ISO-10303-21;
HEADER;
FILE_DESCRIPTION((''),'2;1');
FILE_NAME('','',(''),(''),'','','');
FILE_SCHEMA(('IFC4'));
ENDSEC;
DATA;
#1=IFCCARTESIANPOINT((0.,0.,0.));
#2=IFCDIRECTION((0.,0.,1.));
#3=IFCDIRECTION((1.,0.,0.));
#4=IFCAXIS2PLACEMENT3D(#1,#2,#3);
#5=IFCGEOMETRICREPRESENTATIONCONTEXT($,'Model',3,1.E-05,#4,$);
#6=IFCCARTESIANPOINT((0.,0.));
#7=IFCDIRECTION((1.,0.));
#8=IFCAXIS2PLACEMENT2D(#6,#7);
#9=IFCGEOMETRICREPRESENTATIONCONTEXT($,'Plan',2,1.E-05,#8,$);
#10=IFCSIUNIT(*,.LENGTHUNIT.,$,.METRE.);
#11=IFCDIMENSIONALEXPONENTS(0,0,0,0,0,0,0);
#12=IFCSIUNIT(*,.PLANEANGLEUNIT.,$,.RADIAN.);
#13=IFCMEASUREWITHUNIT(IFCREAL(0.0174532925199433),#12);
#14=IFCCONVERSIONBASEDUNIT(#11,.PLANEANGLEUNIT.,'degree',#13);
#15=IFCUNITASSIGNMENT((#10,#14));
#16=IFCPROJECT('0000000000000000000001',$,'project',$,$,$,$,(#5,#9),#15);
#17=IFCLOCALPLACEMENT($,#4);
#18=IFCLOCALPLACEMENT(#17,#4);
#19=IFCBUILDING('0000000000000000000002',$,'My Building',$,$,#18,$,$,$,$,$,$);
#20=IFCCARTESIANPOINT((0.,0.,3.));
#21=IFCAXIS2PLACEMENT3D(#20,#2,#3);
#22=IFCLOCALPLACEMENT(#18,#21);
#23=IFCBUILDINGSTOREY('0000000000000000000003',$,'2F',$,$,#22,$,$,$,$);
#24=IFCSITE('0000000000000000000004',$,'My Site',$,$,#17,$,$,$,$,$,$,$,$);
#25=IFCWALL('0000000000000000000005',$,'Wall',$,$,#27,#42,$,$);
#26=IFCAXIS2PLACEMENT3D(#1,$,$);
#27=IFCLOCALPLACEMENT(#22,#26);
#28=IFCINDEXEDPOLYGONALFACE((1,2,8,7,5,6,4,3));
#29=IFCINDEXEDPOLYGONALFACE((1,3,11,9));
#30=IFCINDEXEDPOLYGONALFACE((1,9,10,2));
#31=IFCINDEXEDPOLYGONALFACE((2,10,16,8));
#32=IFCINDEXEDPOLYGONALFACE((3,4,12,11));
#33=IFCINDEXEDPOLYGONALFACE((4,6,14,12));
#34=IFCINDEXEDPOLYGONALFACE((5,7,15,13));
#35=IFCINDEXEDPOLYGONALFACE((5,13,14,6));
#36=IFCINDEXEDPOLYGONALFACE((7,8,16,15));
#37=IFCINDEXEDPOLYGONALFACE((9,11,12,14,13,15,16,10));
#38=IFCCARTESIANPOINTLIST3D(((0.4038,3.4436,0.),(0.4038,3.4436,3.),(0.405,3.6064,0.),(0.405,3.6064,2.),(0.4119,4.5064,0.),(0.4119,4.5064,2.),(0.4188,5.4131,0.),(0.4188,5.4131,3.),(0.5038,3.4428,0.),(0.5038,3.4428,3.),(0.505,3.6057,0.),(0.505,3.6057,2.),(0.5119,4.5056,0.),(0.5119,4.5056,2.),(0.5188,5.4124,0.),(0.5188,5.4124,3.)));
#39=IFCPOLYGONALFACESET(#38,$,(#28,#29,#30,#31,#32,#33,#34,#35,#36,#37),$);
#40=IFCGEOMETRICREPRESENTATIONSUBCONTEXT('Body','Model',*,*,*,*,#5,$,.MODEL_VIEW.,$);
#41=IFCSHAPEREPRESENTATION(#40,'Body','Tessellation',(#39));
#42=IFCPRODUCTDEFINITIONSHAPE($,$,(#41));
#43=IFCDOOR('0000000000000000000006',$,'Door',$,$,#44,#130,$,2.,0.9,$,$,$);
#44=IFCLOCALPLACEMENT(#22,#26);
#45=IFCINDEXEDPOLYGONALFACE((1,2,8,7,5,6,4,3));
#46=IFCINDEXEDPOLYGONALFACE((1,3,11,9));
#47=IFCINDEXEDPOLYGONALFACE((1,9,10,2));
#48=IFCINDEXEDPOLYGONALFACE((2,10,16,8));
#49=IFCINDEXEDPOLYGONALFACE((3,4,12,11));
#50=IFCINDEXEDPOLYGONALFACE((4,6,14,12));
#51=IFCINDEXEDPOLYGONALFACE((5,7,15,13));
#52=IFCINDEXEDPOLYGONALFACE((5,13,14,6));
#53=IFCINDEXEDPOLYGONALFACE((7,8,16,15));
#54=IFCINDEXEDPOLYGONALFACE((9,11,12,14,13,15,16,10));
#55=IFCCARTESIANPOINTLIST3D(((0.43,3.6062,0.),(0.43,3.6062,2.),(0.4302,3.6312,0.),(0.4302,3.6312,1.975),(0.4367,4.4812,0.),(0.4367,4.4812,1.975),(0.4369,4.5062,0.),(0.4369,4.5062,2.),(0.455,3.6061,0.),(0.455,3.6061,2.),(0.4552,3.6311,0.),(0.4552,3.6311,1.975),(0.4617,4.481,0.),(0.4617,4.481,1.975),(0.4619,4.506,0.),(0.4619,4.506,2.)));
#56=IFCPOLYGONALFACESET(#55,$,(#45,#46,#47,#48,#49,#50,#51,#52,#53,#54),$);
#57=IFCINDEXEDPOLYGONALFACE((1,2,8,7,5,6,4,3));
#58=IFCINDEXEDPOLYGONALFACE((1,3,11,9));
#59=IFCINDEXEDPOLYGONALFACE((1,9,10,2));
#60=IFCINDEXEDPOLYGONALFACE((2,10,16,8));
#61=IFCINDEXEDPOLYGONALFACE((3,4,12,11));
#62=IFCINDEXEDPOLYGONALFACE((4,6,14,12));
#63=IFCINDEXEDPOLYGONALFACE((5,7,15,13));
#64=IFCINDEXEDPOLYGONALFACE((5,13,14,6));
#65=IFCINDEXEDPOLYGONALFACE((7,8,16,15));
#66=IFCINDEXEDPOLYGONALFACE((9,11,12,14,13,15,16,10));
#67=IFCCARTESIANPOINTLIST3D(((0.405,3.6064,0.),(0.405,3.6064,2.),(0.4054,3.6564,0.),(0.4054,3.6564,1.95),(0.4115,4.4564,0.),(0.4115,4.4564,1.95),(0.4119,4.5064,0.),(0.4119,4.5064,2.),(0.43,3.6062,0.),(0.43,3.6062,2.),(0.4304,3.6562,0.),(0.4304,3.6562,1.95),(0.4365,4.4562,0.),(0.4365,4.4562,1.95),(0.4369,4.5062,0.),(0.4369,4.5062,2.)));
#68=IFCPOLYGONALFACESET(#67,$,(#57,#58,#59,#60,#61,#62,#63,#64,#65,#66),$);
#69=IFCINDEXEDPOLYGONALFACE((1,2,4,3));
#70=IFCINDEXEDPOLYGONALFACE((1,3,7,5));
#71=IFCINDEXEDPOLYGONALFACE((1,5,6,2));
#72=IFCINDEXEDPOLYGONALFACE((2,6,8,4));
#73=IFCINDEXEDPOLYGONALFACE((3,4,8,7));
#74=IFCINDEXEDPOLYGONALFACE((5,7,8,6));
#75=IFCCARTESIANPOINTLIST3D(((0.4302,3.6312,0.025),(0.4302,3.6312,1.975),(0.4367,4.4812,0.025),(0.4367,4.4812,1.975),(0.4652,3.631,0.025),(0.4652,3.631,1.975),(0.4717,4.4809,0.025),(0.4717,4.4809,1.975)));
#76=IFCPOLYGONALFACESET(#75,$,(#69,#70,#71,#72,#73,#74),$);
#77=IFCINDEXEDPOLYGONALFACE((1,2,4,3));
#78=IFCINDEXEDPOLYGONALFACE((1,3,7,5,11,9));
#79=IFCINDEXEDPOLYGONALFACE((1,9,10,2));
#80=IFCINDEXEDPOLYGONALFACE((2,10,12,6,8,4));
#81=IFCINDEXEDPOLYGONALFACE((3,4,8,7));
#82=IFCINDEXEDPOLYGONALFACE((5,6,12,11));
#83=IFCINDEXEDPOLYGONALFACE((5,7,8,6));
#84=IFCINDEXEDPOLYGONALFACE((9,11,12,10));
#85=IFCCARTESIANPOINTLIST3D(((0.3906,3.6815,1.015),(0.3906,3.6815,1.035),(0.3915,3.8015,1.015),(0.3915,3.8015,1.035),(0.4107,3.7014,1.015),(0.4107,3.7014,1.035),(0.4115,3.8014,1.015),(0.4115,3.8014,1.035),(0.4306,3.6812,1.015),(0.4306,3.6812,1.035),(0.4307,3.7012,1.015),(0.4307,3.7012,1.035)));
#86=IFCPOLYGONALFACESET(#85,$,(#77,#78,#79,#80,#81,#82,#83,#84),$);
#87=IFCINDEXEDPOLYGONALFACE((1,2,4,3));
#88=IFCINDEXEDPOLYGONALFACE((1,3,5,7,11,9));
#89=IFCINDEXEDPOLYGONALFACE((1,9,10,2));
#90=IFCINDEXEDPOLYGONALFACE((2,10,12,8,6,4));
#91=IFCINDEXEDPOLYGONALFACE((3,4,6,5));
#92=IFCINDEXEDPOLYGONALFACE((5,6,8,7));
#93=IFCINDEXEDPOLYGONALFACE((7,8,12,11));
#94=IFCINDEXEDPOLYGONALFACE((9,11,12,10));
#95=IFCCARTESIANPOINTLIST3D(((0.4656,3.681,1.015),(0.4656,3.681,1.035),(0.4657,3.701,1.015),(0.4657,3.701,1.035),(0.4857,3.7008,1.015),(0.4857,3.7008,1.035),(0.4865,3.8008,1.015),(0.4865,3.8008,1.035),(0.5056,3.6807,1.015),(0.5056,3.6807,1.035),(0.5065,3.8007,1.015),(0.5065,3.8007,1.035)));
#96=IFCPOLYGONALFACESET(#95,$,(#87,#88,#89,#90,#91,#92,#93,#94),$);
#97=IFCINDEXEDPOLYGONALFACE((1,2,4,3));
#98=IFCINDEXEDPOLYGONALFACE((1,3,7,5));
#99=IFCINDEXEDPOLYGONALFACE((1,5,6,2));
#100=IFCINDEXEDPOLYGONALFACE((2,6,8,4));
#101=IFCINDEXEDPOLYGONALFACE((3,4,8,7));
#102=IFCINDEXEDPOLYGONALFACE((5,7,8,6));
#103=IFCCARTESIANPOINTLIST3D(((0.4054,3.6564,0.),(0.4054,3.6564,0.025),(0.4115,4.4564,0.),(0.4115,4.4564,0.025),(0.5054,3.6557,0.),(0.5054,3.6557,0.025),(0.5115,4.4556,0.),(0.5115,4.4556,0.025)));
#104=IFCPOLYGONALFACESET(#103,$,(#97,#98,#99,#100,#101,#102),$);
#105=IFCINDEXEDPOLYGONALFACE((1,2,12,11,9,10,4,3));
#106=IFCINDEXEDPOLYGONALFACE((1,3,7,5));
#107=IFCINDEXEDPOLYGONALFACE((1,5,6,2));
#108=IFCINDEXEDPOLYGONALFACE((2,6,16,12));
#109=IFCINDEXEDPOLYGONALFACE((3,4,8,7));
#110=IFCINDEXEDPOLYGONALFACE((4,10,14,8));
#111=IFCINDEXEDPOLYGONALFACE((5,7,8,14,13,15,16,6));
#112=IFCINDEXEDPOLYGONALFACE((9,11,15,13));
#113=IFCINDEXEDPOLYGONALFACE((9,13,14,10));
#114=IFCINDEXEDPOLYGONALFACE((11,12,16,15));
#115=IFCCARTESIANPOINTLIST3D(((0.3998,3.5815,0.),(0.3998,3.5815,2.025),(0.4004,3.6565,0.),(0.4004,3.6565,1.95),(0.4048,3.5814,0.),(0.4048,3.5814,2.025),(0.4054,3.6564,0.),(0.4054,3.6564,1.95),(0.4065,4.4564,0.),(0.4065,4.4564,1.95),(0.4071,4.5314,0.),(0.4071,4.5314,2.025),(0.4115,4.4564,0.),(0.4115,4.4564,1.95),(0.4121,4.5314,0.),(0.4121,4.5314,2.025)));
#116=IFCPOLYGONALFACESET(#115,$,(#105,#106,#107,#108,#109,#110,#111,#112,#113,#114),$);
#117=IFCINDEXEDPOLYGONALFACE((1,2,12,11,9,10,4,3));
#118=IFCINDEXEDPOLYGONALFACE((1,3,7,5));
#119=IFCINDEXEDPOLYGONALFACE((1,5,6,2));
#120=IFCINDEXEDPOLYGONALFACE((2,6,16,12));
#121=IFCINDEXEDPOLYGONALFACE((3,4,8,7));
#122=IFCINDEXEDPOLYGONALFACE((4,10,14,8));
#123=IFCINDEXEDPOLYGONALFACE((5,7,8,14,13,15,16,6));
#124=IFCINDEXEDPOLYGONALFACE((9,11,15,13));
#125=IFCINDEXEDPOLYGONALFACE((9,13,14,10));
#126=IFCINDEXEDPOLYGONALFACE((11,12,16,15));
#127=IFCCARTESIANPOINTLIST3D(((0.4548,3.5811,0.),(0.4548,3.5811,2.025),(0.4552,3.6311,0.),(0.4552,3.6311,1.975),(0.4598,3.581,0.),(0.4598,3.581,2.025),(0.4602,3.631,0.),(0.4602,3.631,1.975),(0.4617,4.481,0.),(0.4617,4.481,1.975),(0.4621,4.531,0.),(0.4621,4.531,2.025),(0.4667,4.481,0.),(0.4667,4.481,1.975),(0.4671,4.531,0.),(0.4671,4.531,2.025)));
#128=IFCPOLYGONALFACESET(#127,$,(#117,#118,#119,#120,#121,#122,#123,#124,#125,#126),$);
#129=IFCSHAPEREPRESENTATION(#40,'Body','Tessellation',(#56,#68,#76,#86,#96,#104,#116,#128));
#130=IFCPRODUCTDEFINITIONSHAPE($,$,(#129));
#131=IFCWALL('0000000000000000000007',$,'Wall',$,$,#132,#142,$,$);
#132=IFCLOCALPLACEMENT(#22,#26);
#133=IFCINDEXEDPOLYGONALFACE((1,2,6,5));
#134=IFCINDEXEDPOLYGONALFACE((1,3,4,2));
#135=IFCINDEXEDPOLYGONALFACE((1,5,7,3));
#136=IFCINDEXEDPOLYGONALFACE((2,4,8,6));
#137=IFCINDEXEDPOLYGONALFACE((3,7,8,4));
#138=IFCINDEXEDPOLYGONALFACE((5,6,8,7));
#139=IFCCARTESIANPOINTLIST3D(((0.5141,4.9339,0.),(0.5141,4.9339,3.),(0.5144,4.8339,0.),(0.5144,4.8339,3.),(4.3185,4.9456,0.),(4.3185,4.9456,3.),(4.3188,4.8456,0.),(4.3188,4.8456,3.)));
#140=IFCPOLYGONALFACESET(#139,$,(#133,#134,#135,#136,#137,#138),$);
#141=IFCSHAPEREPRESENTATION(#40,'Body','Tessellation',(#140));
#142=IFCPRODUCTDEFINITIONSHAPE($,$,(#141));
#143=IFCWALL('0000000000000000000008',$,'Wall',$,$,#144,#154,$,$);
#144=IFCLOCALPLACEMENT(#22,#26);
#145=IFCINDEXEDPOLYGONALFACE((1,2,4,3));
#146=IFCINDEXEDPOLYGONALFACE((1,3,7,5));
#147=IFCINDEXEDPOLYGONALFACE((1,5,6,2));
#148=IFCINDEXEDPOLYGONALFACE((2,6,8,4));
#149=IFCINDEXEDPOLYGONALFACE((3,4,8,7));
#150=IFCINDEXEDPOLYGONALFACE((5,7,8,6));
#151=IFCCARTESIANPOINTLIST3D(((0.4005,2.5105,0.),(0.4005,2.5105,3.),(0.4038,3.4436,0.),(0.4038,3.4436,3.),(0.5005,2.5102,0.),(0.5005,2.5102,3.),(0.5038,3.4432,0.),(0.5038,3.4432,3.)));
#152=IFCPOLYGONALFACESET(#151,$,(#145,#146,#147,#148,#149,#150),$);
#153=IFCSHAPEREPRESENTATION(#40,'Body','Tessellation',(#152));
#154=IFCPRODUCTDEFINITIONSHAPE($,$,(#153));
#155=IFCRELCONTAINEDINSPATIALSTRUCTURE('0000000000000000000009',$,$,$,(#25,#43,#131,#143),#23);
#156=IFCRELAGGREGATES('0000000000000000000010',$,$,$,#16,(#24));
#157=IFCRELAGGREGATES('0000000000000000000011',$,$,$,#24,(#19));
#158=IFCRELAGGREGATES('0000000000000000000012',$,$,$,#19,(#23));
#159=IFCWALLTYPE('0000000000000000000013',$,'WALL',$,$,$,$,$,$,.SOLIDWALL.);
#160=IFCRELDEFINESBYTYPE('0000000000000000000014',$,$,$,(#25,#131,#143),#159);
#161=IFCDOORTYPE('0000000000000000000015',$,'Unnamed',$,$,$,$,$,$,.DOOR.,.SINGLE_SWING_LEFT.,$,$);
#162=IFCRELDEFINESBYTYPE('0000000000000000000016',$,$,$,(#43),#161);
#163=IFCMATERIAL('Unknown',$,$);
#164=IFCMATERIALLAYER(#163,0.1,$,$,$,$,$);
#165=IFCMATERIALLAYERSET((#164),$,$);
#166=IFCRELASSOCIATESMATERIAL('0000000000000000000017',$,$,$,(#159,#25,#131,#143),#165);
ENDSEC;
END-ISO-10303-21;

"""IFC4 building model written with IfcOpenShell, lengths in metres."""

from ifc_helpers import new_model, entity, si_unit, converted_unit, frame, origin_with_axes, origin_2d_with_axis, place, context, subcontext, project, spatial, line, indexed_curve, outline, extrude, shape, source, transform, mapped, material, layer, layer_set, layer_usage, type_object, type_shapes, element, fill, save


model = new_model("IFC4")

# Units and contexts
model_context = context("Model", 3, precision=1e-05, world=origin_with_axes())
plan_context = context("Plan", 2, precision=1e-05, world=origin_2d_with_axis())
body_context_1 = subcontext(model_context, "Body", "Model", "MODEL_VIEW")
body_context_2 = subcontext(plan_context, "Body", "Plan", "PLAN_VIEW")
ifc_project = project(units=[si_unit("LENGTHUNIT", "METRE"), converted_unit("PLANEANGLEUNIT", "degree", entity("IfcReal", 0.0174532925199433), si_unit("PLANEANGLEUNIT", "RADIAN"), dimensions=[0, 0, 0, 0, 0, 0, 0])], contexts=[model_context, plan_context])

# Site, building, storey
site_placement = place(None, origin_with_axes())
site = spatial("IfcSite", under=ifc_project, at=site_placement, Name="My Site")
building_placement = place(site_placement, origin_with_axes())
building = spatial("IfcBuilding", under=site, at=building_placement, Name="My Building")
storey_placement = place(building_placement, frame((0.0, 0.0, 3.0), z_axis=(0.0, 0.0, 1.0), x_axis=(1.0, 0.0, 0.0)))
storey = spatial("IfcBuildingStorey", under=building, at=storey_placement, Name="2F")

# Shared definitions
ifc_material = material(Name="Unknown")

# Shared definitions
ifc_layer_1 = layer(ifc_material, 0.1)
ifc_layer_set_1 = layer_set([ifc_layer_1])
wall_type = type_object("IfcWallType", Name="WALL", PredefinedType="SOLIDWALL", material=ifc_layer_set_1)

# Wall, opening, door
ifc_layer_usage_1 = layer_usage(ifc_layer_set_1, "AXIS2", "POSITIVE", 0.0)
wall_1_placement = place(storey_placement, frame((0.4188, 5.4131, 0.0), z_axis=(0.0, 0.0, 1.0), x_axis=(-0.007642, -0.999971, 0.0)))
wall_1 = element("IfcWall", 1, at=wall_1_placement, inside=storey, type_object=wall_type, material=ifc_layer_usage_1, Name="Wall", context=body_context_1, shape_type="SweptSolid", body=[
    extrude(outline(indexed_curve([(0.0, 0.0), (0.0, 0.1), (1.9696, 0.1), (1.9696, 0.0)], segments=[line(1, 2, 3, 4, 1)])), origin_with_axes(), (0.0, 0.0, 1.0), 3.0),
])
shared_shape_1 = source(origin_with_axes(), body_context_1, "Body", "SweptSolid", [
    extrude(outline(indexed_curve([(0.0, 0.0), (0.9, 0.0), (0.9, 2.0), (0.0, 2.0)], segments=[line(1, 2, 3, 4, 1)])), frame((0.0, -0.6, 0.0), z_axis=(0.0, -1.0, 0.0), x_axis=(1.0, 0.0, 0.0)), (0.0, 0.0, -1.0), 1.2),
])
opening_1_placement = place(wall_1_placement, frame((0.9067, 0.0, 0.0), z_axis=(0.0, 0.0, 1.0), x_axis=(1.0, 0.0, 0.0)))
opening_1 = element("IfcOpeningElement", 2, at=opening_1_placement, cuts=wall_1, PredefinedType="OPENING", context=body_context_1, shape_type="MappedRepresentation", body=[
    mapped(shared_shape_1, transform((0.0, 0.0, 0.0), x_axis=(1.0, 0.0, 0.0), y_axis=(0.0, 1.0, 0.0), z_axis=(0.0, 0.0, 1.0), scale=1.0)),
])
door_type = type_object("IfcDoorType", Name="Unnamed", OperationType="SINGLE_SWING_LEFT", PredefinedType="DOOR")
shared_shape_2 = source(origin_with_axes(), body_context_1, "Body", "SweptSolid", [
    extrude(outline(indexed_curve([(0.0, 0.0), (0.0, 2.0), (0.9, 2.0), (0.9, 0.0), (0.875, 0.0), (0.875, 1.975), (0.025, 1.975), (0.025, 0.0)], segments=[line(1, 2, 3, 4, 5, 6, 7, 8, 1)])), frame((0.0, 0.025, 0.0), z_axis=(0.0, -1.0, 0.0), x_axis=(1.0, 0.0, 0.0)), (0.0, 0.0, -1.0), 0.025),
    extrude(outline(indexed_curve([(0.0, 0.0), (0.0, 2.0), (0.9, 2.0), (0.9, 0.0), (0.85, 0.0), (0.85, 1.95), (0.05, 1.95), (0.05, 0.0)], segments=[line(1, 2, 3, 4, 5, 6, 7, 8, 1)])), frame((0.0, 0.0, 0.0), z_axis=(0.0, -1.0, 0.0), x_axis=(1.0, 0.0, 0.0)), (0.0, 0.0, -1.0), 0.025),
    extrude(outline(indexed_curve([(0.0, 0.0), (0.85, 0.0), (0.85, 0.035), (0.0, 0.035)], segments=[line(1, 2, 3, 4, 1)])), frame((0.025, 0.025, 0.025), z_axis=(0.0, 0.0, 1.0), x_axis=(1.0, 0.0, 0.0)), (0.0, 0.0, 1.0), 1.95),
    extrude(outline(indexed_curve([(0.0, 0.0), (0.0, -0.04), (-0.12, -0.04), (-0.12, -0.02), (-0.02, -0.02), (-0.02, 0.0)], segments=[line(1, 2, 3, 4, 5, 6, 1)])), frame((0.825, 0.025, 1.015), z_axis=(0.0, 0.0, 1.0), x_axis=(1.0, 0.0, 0.0)), (0.0, 0.0, 1.0), 0.02),
    extrude(outline(indexed_curve([(0.0, 0.0), (0.0, 0.04), (-0.12, 0.04), (-0.12, 0.02), (-0.02, 0.02), (-0.02, 0.0)], segments=[line(1, 2, 3, 4, 5, 6, 1)])), frame((0.825, 0.06, 1.015), z_axis=(0.0, 0.0, 1.0), x_axis=(1.0, 0.0, 0.0)), (0.0, 0.0, 1.0), 0.02),
    extrude(outline(indexed_curve([(0.0, 0.0), (0.8, 0.0), (0.8, 0.1), (0.0, 0.1)], segments=[line(1, 2, 3, 4, 1)])), frame((0.05, 0.0, 0.0), z_axis=(0.0, 0.0, 1.0), x_axis=(1.0, 0.0, 0.0)), (0.0, 0.0, 1.0), 0.025),
    extrude(outline(indexed_curve([(0.0, 0.0), (0.0, 2.025), (0.95, 2.025), (0.95, 0.0), (0.875, 0.0), (0.875, 1.95), (0.075, 1.95), (0.075, 0.0)], segments=[line(1, 2, 3, 4, 5, 6, 7, 8, 1)])), frame((-0.025, -0.005, 0.0), z_axis=(0.0, -1.0, 0.0), x_axis=(1.0, 0.0, 0.0)), (0.0, 0.0, -1.0), 0.005),
    extrude(outline(indexed_curve([(0.0, 0.0), (0.0, 2.025), (0.95, 2.025), (0.95, 0.0), (0.9, 0.0), (0.9, 1.975), (0.05, 1.975), (0.05, 0.0)], segments=[line(1, 2, 3, 4, 5, 6, 7, 8, 1)])), frame((-0.025, 0.05, 0.0), z_axis=(0.0, -1.0, 0.0), x_axis=(1.0, 0.0, 0.0)), (0.0, 0.0, -1.0), 0.005),
])
shared_shape_3 = source(origin_with_axes(), body_context_2, "Body", "Curve2D", [
    entity("IfcIndexedPolyCurve", entity("IfcCartesianPointList2D", [[0.0, 0.0], [0.0, 0.05], [0.025, 0.05], [0.025, 0.025], [0.05, 0.025], [0.05, 0.0]]), [entity("IfcLineIndex", [1, 2, 3, 4, 5, 6, 1])]),
    entity("IfcIndexedPolyCurve", entity("IfcCartesianPointList2D", [[0.9, 0.0], [0.9, 0.05], [0.875, 0.05], [0.875, 0.025], [0.85, 0.025], [0.85, 0.0]]), [entity("IfcLineIndex", [1, 2, 3, 4, 5, 6, 1])]),
    entity("IfcTrimmedCurve", entity("IfcEllipse", entity("IfcAxis2Placement2D", entity("IfcCartesianPoint", [0.06, 0.05]), entity("IfcDirection", [1.0, 0.0])), 0.815, 0.85), [entity("IfcCartesianPoint", [0.875, 0.05])], [entity("IfcCartesianPoint", [0.06, 0.9])], True, "CARTESIAN"),
    entity("IfcIndexedPolyCurve", entity("IfcCartesianPointList2D", [[0.025, 0.05], [0.06, 0.05], [0.06, 0.9], [0.025, 0.9]]), [entity("IfcLineIndex", [1, 2, 3, 4, 1])]),
])
type_shapes(door_type, [shared_shape_2, shared_shape_3])
door_1_placement = place(opening_1_placement, frame((0.0, 0.0, 0.0), z_axis=(0.0, 0.0, 1.0), x_axis=(1.0, 0.0, 0.0)))
door_1 = element("IfcDoor", 3, at=door_1_placement, inside=storey, type_object=door_type, Name="Door", OverallHeight=2.0, OverallWidth=0.9, shapes=[
    shape(body_context_1, "Body", "MappedRepresentation", [mapped(shared_shape_2, transform((0.0, 0.0, 0.0), x_axis=(1.0, 0.0, 0.0), y_axis=(0.0, 1.0, 0.0), z_axis=(0.0, 0.0, 1.0), scale=1.0))]),
    shape(body_context_2, "Body", "MappedRepresentation", [mapped(shared_shape_3, transform((0.0, 0.0, 0.0), x_axis=(1.0, 0.0, 0.0), y_axis=(0.0, 1.0, 0.0), z_axis=(0.0, 0.0, 1.0), scale=1.0))]),
])
fill(opening_1, door_1)

# Walls
ifc_layer_usage_2 = layer_usage(ifc_layer_set_1, "AXIS2", "POSITIVE", 0.0)
wall_2_placement = place(storey_placement, frame((0.5144, 4.8339, 0.0), z_axis=(0.0, 0.0, 1.0), x_axis=(0.999995, 0.003068, 0.0)))
element("IfcWall", 4, at=wall_2_placement, inside=storey, type_object=wall_type, material=ifc_layer_usage_2, Name="Wall", context=body_context_1, shape_type="SweptSolid", body=[
    extrude(outline(indexed_curve([(0.0, 0.0), (0.0, 0.1), (3.8044, 0.1), (3.8044, 0.0)], segments=[line(1, 2, 3, 4, 1)])), origin_with_axes(), (0.0, 0.0, 1.0), 3.0),
])
ifc_layer_usage_3 = layer_usage(ifc_layer_set_1, "AXIS2", "POSITIVE", 0.0)
wall_3_placement = place(storey_placement, frame((0.4038, 3.4436, 0.0), z_axis=(0.0, 0.0, 1.0), x_axis=(-0.003501, -0.999994, 0.0)))
element("IfcWall", 5, at=wall_3_placement, inside=storey, type_object=wall_type, material=ifc_layer_usage_3, Name="Wall", context=body_context_1, shape_type="SweptSolid", body=[
    extrude(outline(indexed_curve([(0.0, 0.0), (0.0, 0.1), (0.933, 0.1), (0.933, 0.0)], segments=[line(1, 2, 3, 4, 1)])), origin_with_axes(), (0.0, 0.0, 1.0), 3.0),
])

save(model, "model.ifc")
